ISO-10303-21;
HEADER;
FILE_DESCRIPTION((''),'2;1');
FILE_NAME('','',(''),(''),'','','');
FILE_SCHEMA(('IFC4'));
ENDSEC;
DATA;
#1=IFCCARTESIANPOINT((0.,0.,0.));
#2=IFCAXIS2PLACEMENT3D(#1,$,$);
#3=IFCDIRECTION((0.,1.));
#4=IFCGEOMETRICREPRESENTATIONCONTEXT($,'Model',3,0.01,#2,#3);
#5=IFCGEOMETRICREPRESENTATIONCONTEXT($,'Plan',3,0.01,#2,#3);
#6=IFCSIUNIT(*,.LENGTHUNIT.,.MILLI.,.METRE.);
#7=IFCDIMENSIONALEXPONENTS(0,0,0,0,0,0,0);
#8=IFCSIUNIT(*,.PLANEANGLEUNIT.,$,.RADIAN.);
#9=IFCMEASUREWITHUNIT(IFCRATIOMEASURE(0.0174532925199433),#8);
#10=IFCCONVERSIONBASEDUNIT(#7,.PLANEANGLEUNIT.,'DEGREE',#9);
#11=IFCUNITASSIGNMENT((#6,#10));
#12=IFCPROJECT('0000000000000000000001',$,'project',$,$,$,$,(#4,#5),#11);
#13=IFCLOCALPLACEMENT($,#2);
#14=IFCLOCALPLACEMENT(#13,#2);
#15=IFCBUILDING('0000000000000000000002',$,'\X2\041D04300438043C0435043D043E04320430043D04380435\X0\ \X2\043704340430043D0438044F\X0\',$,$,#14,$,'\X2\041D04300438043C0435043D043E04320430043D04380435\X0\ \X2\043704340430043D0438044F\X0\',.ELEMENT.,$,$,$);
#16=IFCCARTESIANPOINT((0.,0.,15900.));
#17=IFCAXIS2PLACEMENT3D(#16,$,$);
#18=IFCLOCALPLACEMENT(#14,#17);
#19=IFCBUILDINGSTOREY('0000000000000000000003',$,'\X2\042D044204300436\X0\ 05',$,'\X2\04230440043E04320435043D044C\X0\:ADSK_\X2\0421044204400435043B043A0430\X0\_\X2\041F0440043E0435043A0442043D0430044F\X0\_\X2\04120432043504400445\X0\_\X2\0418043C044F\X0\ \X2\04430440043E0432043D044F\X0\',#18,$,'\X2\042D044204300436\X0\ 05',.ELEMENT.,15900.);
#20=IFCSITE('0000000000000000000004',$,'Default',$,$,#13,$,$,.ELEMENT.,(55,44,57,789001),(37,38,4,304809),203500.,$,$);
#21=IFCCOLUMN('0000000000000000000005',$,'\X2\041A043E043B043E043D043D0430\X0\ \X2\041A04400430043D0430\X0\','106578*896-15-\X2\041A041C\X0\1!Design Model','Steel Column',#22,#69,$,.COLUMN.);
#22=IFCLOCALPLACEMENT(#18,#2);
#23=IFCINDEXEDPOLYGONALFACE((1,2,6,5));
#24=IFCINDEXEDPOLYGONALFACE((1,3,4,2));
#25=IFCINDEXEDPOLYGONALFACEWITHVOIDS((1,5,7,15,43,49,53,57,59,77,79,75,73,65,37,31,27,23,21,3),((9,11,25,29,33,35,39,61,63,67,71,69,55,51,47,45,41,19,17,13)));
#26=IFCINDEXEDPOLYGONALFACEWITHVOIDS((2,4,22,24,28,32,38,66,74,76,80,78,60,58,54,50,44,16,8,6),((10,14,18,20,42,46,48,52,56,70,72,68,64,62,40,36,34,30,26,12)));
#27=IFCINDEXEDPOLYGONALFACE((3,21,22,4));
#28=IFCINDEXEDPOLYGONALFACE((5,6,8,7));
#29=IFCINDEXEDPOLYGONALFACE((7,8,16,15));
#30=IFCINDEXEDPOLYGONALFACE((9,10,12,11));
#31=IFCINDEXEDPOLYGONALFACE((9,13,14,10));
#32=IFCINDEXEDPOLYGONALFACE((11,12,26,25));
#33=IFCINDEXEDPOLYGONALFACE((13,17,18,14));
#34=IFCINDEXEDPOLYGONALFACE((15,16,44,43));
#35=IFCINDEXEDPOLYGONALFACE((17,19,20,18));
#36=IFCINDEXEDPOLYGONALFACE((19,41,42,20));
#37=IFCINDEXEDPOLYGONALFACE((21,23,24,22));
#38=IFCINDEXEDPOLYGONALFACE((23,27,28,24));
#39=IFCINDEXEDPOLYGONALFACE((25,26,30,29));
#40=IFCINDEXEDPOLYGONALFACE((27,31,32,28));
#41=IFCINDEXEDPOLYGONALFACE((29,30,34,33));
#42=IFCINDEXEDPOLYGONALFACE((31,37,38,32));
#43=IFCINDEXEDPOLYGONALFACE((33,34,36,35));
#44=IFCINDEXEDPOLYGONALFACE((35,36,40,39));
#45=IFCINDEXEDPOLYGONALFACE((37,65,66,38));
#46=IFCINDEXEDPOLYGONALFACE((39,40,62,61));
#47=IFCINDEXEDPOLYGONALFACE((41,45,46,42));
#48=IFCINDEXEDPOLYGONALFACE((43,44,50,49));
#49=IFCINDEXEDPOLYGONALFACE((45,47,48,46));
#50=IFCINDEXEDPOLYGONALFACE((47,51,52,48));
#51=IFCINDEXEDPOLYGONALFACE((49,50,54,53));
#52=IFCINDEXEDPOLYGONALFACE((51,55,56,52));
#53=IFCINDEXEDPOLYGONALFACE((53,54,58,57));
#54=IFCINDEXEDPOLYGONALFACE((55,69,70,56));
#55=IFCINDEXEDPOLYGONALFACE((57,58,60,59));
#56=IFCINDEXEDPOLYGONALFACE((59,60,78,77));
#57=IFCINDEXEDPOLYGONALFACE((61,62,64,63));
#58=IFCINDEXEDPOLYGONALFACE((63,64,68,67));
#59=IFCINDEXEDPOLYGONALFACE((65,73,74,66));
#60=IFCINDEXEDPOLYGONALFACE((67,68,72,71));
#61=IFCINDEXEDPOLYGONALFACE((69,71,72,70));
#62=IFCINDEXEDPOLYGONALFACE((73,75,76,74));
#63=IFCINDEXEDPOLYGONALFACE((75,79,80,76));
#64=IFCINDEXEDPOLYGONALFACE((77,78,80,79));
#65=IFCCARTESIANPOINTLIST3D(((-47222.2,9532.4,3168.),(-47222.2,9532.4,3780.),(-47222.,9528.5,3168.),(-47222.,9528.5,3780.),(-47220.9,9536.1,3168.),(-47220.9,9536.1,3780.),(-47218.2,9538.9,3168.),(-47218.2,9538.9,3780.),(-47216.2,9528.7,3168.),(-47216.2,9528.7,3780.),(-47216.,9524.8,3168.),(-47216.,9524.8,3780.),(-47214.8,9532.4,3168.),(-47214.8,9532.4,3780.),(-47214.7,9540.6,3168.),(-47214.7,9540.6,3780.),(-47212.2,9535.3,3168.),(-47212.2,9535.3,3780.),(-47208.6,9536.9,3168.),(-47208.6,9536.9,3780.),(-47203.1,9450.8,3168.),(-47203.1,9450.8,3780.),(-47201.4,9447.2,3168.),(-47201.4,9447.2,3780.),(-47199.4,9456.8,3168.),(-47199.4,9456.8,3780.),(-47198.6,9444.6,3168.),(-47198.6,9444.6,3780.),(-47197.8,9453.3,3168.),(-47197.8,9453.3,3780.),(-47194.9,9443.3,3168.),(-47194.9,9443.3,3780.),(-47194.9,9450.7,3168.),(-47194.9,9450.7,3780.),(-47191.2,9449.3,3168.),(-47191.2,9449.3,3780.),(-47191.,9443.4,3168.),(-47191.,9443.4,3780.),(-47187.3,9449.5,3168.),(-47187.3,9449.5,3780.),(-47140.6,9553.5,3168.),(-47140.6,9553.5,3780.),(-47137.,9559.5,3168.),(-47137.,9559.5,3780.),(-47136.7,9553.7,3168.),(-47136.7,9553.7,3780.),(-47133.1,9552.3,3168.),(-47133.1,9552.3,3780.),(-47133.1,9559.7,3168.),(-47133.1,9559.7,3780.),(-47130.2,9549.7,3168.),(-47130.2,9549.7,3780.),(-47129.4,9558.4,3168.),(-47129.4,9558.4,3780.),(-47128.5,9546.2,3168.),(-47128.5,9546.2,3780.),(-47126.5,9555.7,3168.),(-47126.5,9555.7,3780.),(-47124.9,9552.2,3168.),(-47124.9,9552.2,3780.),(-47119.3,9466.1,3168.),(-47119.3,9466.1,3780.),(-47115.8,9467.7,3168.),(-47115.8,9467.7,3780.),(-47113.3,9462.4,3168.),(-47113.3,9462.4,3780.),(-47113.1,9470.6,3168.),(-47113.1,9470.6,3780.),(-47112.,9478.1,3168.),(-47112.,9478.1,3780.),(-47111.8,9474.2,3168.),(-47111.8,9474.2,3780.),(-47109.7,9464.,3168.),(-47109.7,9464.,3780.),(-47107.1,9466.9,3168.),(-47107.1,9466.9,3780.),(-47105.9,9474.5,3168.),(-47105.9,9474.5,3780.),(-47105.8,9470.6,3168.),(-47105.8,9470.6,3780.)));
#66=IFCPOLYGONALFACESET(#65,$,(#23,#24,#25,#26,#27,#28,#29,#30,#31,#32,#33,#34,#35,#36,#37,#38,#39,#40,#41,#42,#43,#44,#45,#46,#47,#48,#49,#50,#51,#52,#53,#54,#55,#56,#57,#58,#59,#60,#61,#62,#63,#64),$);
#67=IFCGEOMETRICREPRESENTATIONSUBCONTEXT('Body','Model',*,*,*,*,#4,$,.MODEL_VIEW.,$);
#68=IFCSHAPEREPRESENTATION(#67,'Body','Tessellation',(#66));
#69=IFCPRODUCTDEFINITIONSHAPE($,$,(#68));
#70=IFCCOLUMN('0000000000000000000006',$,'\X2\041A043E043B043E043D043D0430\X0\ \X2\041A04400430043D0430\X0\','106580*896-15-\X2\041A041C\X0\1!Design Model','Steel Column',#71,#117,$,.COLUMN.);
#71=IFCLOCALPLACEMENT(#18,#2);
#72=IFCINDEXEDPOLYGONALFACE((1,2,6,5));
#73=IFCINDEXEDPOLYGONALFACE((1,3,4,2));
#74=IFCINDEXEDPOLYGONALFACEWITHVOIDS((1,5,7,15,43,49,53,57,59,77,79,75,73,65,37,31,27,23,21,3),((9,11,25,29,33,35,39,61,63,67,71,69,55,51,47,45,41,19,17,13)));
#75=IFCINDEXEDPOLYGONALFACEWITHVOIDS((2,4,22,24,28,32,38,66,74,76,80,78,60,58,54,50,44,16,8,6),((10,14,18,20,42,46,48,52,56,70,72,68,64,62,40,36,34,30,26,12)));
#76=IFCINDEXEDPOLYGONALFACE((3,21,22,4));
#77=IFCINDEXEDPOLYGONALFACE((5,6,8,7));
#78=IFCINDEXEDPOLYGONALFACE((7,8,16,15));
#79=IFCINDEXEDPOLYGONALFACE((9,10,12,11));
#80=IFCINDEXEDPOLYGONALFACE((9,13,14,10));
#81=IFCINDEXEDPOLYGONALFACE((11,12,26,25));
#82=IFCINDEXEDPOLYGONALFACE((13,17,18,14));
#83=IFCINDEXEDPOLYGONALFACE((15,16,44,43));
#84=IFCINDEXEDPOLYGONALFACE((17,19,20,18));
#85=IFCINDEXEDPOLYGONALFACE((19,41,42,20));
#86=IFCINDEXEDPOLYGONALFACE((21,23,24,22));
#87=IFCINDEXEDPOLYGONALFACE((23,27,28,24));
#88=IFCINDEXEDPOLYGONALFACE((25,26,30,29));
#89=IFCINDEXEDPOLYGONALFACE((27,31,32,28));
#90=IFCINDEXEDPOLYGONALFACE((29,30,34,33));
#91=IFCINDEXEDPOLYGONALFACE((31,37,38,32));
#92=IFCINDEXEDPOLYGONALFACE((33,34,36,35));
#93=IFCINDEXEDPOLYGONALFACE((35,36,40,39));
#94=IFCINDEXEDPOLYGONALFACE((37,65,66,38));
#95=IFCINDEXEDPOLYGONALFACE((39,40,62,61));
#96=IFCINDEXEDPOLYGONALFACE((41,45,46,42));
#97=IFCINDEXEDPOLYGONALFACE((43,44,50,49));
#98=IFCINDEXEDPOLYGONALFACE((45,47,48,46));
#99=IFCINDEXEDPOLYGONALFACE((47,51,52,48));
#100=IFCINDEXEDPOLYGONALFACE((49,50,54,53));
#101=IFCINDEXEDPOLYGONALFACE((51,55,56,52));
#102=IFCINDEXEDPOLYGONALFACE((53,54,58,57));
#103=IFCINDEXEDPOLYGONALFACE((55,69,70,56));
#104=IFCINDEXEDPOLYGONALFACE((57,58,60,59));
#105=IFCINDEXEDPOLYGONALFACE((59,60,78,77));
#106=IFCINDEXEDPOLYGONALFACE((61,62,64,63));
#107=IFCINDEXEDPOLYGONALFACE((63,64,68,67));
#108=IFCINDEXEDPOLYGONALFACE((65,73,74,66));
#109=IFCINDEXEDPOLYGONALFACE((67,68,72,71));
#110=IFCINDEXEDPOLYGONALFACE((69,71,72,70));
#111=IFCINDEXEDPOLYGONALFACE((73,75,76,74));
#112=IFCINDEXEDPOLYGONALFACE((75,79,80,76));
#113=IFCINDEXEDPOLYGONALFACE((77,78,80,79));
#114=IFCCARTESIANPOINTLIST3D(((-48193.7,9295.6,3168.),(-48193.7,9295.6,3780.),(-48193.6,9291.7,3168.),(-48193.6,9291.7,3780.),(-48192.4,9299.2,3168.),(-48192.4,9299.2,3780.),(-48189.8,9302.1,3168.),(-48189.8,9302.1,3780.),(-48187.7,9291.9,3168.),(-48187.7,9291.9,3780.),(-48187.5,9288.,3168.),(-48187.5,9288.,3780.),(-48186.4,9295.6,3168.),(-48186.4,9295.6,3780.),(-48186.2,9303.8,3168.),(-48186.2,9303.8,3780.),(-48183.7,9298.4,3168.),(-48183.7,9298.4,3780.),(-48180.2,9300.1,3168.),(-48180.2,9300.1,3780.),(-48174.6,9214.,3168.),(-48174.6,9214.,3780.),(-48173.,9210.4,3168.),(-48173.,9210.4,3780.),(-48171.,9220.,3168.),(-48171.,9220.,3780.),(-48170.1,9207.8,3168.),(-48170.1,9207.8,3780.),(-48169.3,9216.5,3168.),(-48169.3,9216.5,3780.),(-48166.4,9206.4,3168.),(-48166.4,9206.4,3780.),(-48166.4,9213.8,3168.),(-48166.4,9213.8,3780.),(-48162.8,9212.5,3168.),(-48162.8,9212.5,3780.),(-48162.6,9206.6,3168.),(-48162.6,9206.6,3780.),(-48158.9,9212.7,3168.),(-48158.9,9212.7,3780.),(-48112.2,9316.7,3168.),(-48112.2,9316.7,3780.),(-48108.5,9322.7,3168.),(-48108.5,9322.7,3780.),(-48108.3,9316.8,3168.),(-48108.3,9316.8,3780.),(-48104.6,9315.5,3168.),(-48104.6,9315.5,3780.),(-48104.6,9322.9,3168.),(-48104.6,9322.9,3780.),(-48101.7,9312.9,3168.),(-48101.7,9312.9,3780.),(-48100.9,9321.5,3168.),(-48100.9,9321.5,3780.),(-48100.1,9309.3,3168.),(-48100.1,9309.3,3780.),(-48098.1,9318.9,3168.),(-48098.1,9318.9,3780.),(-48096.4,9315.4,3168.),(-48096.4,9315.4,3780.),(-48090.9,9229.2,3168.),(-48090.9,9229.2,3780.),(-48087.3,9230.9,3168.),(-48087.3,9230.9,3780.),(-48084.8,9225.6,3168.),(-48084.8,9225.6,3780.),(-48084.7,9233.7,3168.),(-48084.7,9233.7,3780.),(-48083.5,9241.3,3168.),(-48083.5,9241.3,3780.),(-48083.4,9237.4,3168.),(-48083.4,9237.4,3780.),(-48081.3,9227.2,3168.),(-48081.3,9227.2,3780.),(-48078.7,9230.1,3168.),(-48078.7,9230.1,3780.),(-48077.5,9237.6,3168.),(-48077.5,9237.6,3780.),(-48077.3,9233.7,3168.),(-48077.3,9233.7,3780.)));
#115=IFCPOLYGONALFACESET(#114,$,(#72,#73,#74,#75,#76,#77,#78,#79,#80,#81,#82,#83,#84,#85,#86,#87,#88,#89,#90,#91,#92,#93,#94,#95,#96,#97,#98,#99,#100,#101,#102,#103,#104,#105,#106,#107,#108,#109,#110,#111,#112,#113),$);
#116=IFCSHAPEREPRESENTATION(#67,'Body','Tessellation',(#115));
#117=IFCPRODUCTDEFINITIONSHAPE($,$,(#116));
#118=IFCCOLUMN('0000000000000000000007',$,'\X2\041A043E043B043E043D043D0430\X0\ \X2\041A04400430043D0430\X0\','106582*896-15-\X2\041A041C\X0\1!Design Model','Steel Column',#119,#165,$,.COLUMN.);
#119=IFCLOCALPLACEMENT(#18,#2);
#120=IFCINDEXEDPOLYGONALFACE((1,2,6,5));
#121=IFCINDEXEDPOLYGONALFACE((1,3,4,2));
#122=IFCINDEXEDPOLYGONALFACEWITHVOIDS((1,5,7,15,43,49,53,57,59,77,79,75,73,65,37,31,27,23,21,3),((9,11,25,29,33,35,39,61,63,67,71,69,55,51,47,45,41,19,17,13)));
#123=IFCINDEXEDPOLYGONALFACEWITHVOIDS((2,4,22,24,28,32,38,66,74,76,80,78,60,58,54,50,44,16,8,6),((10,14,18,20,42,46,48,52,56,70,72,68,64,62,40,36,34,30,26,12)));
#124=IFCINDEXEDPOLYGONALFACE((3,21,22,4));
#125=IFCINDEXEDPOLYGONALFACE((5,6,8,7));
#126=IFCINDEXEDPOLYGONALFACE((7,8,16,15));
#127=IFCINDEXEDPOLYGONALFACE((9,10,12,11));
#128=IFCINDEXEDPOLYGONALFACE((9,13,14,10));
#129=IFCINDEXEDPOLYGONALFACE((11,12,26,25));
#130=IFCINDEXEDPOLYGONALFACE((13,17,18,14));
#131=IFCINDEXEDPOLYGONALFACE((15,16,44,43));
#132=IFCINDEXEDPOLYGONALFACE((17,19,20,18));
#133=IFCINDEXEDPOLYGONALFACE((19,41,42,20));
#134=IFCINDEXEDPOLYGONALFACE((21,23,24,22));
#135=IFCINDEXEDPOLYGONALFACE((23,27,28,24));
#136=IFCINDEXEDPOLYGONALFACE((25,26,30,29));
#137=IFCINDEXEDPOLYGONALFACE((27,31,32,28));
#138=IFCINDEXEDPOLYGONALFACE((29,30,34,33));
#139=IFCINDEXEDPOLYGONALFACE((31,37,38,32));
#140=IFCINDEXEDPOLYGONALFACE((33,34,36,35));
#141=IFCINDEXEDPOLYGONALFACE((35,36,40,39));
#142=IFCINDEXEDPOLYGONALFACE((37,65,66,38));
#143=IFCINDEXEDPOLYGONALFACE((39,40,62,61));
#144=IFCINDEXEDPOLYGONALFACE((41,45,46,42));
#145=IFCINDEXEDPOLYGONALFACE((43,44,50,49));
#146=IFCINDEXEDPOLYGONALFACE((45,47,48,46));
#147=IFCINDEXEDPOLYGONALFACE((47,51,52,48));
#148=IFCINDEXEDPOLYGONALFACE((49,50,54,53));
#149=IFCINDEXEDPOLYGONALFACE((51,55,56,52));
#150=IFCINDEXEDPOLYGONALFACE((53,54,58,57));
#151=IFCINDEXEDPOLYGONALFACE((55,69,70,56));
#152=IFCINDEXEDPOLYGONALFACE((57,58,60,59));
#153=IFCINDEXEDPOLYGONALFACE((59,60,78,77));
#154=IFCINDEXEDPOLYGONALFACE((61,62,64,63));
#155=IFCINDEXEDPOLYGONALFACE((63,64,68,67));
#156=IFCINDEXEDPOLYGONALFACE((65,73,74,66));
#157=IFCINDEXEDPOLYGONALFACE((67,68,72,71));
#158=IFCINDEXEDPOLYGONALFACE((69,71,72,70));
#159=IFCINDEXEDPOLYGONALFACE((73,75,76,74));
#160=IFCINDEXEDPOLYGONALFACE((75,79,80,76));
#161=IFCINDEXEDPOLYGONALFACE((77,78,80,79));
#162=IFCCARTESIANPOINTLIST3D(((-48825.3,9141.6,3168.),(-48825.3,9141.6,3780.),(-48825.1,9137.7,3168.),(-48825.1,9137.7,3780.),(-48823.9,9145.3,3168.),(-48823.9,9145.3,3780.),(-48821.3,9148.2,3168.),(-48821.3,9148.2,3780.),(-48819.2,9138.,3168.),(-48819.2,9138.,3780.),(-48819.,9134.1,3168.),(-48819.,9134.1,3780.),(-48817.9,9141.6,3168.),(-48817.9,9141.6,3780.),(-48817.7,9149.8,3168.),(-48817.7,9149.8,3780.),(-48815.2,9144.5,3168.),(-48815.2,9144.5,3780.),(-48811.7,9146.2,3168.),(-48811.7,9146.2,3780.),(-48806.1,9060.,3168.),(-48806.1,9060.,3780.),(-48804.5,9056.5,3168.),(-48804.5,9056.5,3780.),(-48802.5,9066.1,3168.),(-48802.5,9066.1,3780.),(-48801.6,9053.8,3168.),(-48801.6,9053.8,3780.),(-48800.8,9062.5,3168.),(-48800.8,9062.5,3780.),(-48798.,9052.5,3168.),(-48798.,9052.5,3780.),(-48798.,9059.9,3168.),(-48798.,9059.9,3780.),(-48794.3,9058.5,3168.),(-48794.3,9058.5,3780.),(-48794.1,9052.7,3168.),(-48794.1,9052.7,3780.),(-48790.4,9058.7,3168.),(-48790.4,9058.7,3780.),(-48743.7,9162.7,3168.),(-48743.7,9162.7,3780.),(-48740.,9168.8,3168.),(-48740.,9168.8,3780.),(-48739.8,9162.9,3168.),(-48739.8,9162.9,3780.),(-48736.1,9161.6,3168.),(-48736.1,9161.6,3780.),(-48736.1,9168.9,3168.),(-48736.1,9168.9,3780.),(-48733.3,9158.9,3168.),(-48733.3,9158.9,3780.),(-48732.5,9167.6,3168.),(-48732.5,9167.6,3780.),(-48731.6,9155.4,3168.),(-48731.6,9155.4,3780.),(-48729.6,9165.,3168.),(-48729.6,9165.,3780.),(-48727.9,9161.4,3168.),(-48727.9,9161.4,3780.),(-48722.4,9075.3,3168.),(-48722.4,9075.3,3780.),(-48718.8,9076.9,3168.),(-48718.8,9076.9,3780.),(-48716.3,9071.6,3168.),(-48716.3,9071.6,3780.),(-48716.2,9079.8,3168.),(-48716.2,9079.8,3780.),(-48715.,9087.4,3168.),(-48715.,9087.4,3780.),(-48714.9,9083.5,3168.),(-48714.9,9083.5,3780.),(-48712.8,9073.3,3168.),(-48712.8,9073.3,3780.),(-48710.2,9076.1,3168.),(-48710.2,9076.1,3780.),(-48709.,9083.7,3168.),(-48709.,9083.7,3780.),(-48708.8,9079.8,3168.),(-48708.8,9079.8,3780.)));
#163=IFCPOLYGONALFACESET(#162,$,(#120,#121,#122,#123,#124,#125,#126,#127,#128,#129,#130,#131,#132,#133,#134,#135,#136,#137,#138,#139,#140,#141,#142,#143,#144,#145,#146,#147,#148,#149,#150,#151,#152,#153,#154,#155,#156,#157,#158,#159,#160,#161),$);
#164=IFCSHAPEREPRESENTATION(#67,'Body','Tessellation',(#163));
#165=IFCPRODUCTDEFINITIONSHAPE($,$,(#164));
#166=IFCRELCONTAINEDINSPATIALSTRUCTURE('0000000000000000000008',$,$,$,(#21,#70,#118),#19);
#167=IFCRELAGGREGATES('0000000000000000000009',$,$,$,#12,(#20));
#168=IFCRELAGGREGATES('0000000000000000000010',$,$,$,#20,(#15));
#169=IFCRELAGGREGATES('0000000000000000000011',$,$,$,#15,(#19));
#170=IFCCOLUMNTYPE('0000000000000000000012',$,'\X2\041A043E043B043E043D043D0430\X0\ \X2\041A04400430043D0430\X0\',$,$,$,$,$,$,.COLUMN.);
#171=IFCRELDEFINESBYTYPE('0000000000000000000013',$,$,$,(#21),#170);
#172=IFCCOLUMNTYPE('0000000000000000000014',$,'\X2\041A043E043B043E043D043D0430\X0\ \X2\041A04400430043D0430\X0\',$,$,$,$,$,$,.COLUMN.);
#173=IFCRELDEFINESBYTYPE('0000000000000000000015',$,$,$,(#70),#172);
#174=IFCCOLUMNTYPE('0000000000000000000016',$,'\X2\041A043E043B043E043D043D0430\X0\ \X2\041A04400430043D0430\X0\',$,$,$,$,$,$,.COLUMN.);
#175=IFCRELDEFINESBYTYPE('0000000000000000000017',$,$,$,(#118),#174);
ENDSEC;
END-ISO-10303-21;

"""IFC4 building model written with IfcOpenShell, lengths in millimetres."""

from ifc_helpers import new_model, entity, si_unit, converted_unit, direction, frame, origin, place, context, subcontext, project, spatial, indexed_curve, outline, extrude, type_object, element, save


model = new_model("IFC4")

# Units and contexts
model_context = context("Model", 3, precision=0.01, world=origin(), true_north=direction((0.0, 1.0)))
plan_context = context("Plan", 3, precision=0.01, world=origin(), true_north=direction((0.0, 1.0)))
body_context = subcontext(model_context, "Body", "Model", "MODEL_VIEW")
ifc_project = project(units=[si_unit("LENGTHUNIT", "METRE", prefix="MILLI"), converted_unit("PLANEANGLEUNIT", "DEGREE", entity("IfcRatioMeasure", 0.0174532925199433), si_unit("PLANEANGLEUNIT", "RADIAN"), dimensions=[0, 0, 0, 0, 0, 0, 0])], contexts=[model_context, plan_context])

# Site, building, storey
site_placement = place(None, origin())
site = spatial("IfcSite", under=ifc_project, at=site_placement, Name="Default", CompositionType="ELEMENT", RefLatitude=(55, 44, 57, 789001), RefLongitude=(37, 38, 4, 304809), RefElevation=203500.0)
building_placement = place(site_placement, origin())
building = spatial("IfcBuilding", under=site, at=building_placement, Name="Наименование здания", LongName="Наименование здания", CompositionType="ELEMENT")
storey_placement = place(building_placement, frame((0.0, 0.0, 15900.0)))
storey = spatial("IfcBuildingStorey", under=building, at=storey_placement, Name="Этаж 05", ObjectType="Уровень:ADSK_Стрелка_Проектная_Вверх_Имя уровня", LongName="Этаж 05", CompositionType="ELEMENT", Elevation=15900.0)

# Columns
placement = place(storey_placement, origin())
column_type_1 = type_object("IfcColumnType", Name="Колонна Крана", PredefinedType="COLUMN")
element("IfcColumn", 1, at=placement, inside=storey, type_object=column_type_1, Name="Колонна Крана", Description="106578*896-15-КМ1!Design Model", ObjectType="Steel Column", PredefinedType="COLUMN", context=body_context, shape_type="SweptSolid", body=[
    extrude(outline(indexed_curve([(29.5, -56.8), (33.4, -56.8), (37.0, -55.3), (39.7, -52.6), (41.2, -49.0), (56.8, 29.5), (56.8, 33.4), (55.3, 37.0), (52.6, 39.7), (49.0, 41.2), (-29.5, 56.8), (-33.4, 56.8), (-37.0, 55.3), (-39.7, 52.6), (-41.2, 49.0), (-56.8, -29.5), (-56.8, -33.4), (-55.3, -37.0), (-52.6, -39.7), (-49.0, -41.2), (29.5, -56.8)], self_intersect=False), holes=[indexed_curve([(-43.1, -37.3), (-46.7, -35.8), (-49.5, -33.1), (-51.0, -29.5), (-51.0, -25.5), (-37.3, 43.1), (-35.8, 46.7), (-33.1, 49.5), (-29.5, 51.0), (-25.5, 51.0), (43.1, 37.3), (46.7, 35.8), (49.5, 33.1), (51.0, 29.5), (51.0, 25.5), (37.3, -43.1), (35.8, -46.7), (33.1, -49.5), (29.5, -51.0), (25.5, -51.0), (-43.1, -37.3)], self_intersect=False)]), frame((-47164.0, 9501.5, 3168.0), z_axis=(0.0, 0.0, 1.0), x_axis=(0.906681, 0.421816, 0.0)), (0.0, 0.0, 1.0), 612.0),
])
column_type_2 = type_object("IfcColumnType", Name="Колонна Крана", PredefinedType="COLUMN")
element("IfcColumn", 2, at=placement, inside=storey, type_object=column_type_2, Name="Колонна Крана", Description="106580*896-15-КМ1!Design Model", ObjectType="Steel Column", PredefinedType="COLUMN", context=body_context, shape_type="SweptSolid", body=[
    extrude(outline(indexed_curve([(29.5, -56.8), (33.4, -56.8), (37.0, -55.3), (39.7, -52.6), (41.2, -49.0), (56.8, 29.5), (56.8, 33.4), (55.3, 37.0), (52.6, 39.7), (49.0, 41.2), (-29.5, 56.8), (-33.4, 56.8), (-37.0, 55.3), (-39.7, 52.6), (-41.2, 49.0), (-56.8, -29.5), (-56.8, -33.4), (-55.3, -37.0), (-52.6, -39.7), (-49.0, -41.2), (29.5, -56.8)], self_intersect=False), holes=[indexed_curve([(-43.1, -37.3), (-46.7, -35.8), (-49.5, -33.1), (-51.0, -29.5), (-51.0, -25.5), (-37.3, 43.1), (-35.8, 46.7), (-33.1, 49.5), (-29.5, 51.0), (-25.5, 51.0), (43.1, 37.3), (46.7, 35.8), (49.5, 33.1), (51.0, 29.5), (51.0, 25.5), (37.3, -43.1), (35.8, -46.7), (33.1, -49.5), (29.5, -51.0), (25.5, -51.0), (-43.1, -37.3)], self_intersect=False)]), frame((-48135.5, 9264.7, 3168.0), z_axis=(0.0, 0.0, 1.0), x_axis=(0.906681, 0.421816, 0.0)), (0.0, 0.0, 1.0), 612.0),
])
column_type_3 = type_object("IfcColumnType", Name="Колонна Крана", PredefinedType="COLUMN")
element("IfcColumn", 3, at=placement, inside=storey, type_object=column_type_3, Name="Колонна Крана", Description="106582*896-15-КМ1!Design Model", ObjectType="Steel Column", PredefinedType="COLUMN", context=body_context, shape_type="SweptSolid", body=[
    extrude(outline(indexed_curve([(29.5, -56.8), (33.4, -56.8), (37.0, -55.3), (39.7, -52.6), (41.2, -49.0), (56.8, 29.5), (56.8, 33.4), (55.3, 37.0), (52.6, 39.7), (49.0, 41.2), (-29.5, 56.8), (-33.4, 56.8), (-37.0, 55.3), (-39.7, 52.6), (-41.2, 49.0), (-56.8, -29.5), (-56.8, -33.4), (-55.3, -37.0), (-52.6, -39.7), (-49.0, -41.2), (29.5, -56.8)], self_intersect=False), holes=[indexed_curve([(-43.1, -37.3), (-46.7, -35.8), (-49.5, -33.1), (-51.0, -29.5), (-51.0, -25.5), (-37.3, 43.1), (-35.8, 46.7), (-33.1, 49.5), (-29.5, 51.0), (-25.5, 51.0), (43.1, 37.3), (46.7, 35.8), (49.5, 33.1), (51.0, 29.5), (51.0, 25.5), (37.3, -43.1), (35.8, -46.7), (33.1, -49.5), (29.5, -51.0), (25.5, -51.0), (-43.1, -37.3)], self_intersect=False)]), frame((-48767.0, 9110.7, 3168.0), z_axis=(0.0, 0.0, 1.0), x_axis=(0.906681, 0.421816, 0.0)), (0.0, 0.0, 1.0), 612.0),
])

save(model, "model.ifc")
